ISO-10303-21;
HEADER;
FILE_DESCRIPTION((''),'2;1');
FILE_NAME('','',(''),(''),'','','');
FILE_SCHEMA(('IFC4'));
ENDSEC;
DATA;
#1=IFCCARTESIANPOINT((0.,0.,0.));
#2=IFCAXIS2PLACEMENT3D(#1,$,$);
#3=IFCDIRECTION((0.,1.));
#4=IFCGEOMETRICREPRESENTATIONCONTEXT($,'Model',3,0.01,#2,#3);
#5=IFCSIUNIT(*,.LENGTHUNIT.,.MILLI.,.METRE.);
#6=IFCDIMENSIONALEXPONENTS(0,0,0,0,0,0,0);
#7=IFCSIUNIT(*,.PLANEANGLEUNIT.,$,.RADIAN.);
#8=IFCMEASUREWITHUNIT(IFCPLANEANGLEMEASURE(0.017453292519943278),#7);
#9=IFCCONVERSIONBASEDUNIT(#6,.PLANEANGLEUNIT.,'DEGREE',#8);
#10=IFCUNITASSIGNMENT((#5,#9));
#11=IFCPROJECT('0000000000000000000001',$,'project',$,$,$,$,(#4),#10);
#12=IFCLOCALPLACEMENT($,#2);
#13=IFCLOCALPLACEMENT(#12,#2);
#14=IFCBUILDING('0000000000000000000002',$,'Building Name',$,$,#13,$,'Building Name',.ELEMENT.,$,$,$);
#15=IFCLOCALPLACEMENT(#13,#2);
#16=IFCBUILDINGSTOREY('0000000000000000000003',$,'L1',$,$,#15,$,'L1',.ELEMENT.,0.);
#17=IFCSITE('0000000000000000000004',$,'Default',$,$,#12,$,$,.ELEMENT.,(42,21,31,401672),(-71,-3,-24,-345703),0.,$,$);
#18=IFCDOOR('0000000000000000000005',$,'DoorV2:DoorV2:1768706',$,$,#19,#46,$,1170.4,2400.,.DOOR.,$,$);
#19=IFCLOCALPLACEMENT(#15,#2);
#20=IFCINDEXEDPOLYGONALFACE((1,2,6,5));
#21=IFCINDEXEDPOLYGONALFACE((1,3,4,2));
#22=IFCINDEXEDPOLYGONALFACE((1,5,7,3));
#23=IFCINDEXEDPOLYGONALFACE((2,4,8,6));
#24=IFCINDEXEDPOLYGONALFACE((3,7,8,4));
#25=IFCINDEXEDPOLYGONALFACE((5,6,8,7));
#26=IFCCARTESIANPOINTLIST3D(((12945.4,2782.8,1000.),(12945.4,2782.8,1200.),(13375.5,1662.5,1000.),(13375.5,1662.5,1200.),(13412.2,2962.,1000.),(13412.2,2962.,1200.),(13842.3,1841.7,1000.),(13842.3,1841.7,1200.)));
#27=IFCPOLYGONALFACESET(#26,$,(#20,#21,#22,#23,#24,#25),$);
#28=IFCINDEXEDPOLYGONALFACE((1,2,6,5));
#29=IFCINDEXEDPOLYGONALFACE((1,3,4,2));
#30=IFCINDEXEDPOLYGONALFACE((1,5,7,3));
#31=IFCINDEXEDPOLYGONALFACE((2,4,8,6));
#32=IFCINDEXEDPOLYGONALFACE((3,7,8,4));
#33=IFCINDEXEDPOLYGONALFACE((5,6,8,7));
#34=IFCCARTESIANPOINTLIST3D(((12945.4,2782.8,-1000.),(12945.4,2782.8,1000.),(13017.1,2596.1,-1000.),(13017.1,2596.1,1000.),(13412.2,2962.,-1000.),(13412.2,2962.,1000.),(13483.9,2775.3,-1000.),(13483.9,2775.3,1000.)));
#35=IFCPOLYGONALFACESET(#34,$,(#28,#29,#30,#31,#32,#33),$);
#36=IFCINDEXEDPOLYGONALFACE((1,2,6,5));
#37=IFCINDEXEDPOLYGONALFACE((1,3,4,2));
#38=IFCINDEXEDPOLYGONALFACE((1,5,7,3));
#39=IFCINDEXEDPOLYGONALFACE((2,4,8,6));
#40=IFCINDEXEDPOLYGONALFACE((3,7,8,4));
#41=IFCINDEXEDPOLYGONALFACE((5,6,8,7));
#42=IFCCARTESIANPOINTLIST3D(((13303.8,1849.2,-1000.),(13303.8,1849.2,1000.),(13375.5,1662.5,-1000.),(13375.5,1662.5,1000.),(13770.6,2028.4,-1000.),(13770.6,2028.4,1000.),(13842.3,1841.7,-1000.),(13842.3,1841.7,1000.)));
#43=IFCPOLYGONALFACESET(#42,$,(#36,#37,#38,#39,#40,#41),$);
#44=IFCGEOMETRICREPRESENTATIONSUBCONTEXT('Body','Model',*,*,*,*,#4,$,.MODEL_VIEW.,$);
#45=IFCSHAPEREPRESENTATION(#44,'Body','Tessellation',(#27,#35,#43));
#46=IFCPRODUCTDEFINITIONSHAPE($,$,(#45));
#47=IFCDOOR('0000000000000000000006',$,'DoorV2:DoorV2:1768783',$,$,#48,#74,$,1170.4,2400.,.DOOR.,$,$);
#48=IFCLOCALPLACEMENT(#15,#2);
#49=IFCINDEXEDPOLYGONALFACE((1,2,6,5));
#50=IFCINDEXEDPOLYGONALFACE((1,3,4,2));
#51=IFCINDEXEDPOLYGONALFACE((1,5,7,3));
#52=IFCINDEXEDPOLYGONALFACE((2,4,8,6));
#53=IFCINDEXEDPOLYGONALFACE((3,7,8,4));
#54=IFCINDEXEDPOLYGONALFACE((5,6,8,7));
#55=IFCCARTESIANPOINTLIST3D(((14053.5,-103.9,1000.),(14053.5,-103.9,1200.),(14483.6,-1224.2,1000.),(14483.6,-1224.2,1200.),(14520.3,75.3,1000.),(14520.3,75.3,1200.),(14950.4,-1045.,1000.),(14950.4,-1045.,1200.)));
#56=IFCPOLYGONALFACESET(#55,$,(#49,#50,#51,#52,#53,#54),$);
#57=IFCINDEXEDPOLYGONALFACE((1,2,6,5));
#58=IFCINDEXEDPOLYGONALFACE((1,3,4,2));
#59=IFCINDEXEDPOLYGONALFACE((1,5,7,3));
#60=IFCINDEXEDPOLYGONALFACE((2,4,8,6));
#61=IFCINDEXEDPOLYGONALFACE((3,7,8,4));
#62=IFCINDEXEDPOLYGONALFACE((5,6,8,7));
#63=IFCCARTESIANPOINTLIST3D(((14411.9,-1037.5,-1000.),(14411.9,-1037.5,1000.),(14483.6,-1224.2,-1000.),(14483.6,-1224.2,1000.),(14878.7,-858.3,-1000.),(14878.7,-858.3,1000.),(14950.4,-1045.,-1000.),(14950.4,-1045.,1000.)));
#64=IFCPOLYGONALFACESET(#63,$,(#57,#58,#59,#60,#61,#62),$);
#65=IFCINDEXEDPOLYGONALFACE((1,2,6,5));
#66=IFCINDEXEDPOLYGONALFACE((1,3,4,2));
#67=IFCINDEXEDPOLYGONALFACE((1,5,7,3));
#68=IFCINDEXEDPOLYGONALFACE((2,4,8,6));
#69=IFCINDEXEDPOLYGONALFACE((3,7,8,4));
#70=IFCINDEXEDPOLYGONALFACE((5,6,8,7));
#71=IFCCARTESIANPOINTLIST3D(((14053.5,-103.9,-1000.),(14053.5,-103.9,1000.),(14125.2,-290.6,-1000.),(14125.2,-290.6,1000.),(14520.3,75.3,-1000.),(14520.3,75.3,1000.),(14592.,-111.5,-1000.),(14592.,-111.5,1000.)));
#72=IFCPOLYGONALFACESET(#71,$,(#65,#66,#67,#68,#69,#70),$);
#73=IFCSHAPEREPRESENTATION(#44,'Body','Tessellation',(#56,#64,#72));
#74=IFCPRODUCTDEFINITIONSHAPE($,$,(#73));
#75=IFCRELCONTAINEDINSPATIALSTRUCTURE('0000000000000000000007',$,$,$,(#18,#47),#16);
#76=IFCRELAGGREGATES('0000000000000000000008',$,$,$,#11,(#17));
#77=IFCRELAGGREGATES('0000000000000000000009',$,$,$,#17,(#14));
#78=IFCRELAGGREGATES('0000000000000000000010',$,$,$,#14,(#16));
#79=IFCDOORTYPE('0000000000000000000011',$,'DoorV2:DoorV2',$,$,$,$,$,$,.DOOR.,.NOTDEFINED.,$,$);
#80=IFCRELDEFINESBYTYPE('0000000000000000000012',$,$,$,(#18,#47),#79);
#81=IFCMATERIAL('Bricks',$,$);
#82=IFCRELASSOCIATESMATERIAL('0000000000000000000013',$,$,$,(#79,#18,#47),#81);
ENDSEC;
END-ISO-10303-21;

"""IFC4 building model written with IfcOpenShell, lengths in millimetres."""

from ifc_helpers import new_model, entity, si_unit, converted_unit, direction, frame, origin, place, context, subcontext, project, spatial, indexed_curve, outline, extrude, source, transform, mapped, material, type_object, type_shapes, element, save


model = new_model("IFC4")

# Units and contexts
model_context = context("Model", 3, precision=0.01, world=origin(), true_north=direction((0.0, 1.0)))
body_context = subcontext(model_context, "Body", "Model", "MODEL_VIEW")
ifc_project = project(units=[si_unit("LENGTHUNIT", "METRE", prefix="MILLI"), converted_unit("PLANEANGLEUNIT", "DEGREE", entity("IfcPlaneAngleMeasure", 0.017453292519943278), si_unit("PLANEANGLEUNIT", "RADIAN"), dimensions=[0, 0, 0, 0, 0, 0, 0])], contexts=[model_context])

# Site, building, storey
site_placement = place(None, origin())
site = spatial("IfcSite", under=ifc_project, at=site_placement, Name="Default", CompositionType="ELEMENT", RefLatitude=(42, 21, 31, 401672), RefLongitude=(-71, -3, -24, -345703), RefElevation=0.0)
building_placement = place(site_placement, origin())
building = spatial("IfcBuilding", under=site, at=building_placement, Name="Building Name", LongName="Building Name", CompositionType="ELEMENT")
storey_placement = place(building_placement, origin())
storey = spatial("IfcBuildingStorey", under=building, at=storey_placement, Name="L1", LongName="L1", CompositionType="ELEMENT", Elevation=0.0)

# Doors
ifc_material_1 = material(Name="Bricks")
door_type_1 = type_object("IfcDoorType", Name="DoorV2:DoorV2", OperationType="NOTDEFINED", PredefinedType="DOOR", material=ifc_material_1)
shared_shape_1 = source(origin(), body_context, "Body", "SweptSolid", [
    extrude(outline(indexed_curve([(-250.0, -600.0), (250.0, -600.0), (250.0, 600.0), (-250.0, 600.0), (-250.0, -600.0)], self_intersect=False)), frame((0.0, 0.0, 2000.0), z_axis=(0.0, 0.0, 1.0), x_axis=(0.0, 1.0, 0.0)), (0.0, 0.0, 1.0), 200.0),
    extrude(outline(indexed_curve([(-250.0, -100.0), (250.0, -100.0), (250.0, 100.0), (-250.0, 100.0), (-250.0, -100.0)], self_intersect=False)), frame((500.0, 0.0, 0.0), z_axis=(0.0, 0.0, 1.0), x_axis=(0.0, 1.0, 0.0)), (0.0, 0.0, 1.0), 2000.0),
    extrude(outline(indexed_curve([(-250.0, -100.0), (250.0, -100.0), (250.0, 100.0), (-250.0, 100.0), (-250.0, -100.0)], self_intersect=False)), frame((-500.0, 0.0, 0.0), z_axis=(0.0, 0.0, 1.0), x_axis=(0.0, 1.0, 0.0)), (0.0, 0.0, 1.0), 2000.0),
])
type_shapes(door_type_1, [shared_shape_1])
for number, where, z_axis, x_axis, name in (
    (1, (13393.9, 2312.2, -1000.0), (0.0, 0.0, 1.0), (-0.358368, 0.93358, 0.0), "DoorV2:DoorV2:1768706"),
    (2, (14502.0, -574.5, -1000.0), (0.0, 0.0, 1.0), (0.358368, -0.93358, 0.0), "DoorV2:DoorV2:1768783"),
):
    element("IfcDoor", number, at=place(storey_placement, frame(where, z_axis=z_axis, x_axis=x_axis)), inside=storey, type_object=door_type_1, material=ifc_material_1, Name=name, OverallHeight=1170.4, OverallWidth=2400.0, PredefinedType="DOOR", context=body_context, shape_type="MappedRepresentation", body=[
        mapped(shared_shape_1, transform((0.0, 0.0, 0.0), scale=1.0)),
    ])

save(model, "model.ifc")
